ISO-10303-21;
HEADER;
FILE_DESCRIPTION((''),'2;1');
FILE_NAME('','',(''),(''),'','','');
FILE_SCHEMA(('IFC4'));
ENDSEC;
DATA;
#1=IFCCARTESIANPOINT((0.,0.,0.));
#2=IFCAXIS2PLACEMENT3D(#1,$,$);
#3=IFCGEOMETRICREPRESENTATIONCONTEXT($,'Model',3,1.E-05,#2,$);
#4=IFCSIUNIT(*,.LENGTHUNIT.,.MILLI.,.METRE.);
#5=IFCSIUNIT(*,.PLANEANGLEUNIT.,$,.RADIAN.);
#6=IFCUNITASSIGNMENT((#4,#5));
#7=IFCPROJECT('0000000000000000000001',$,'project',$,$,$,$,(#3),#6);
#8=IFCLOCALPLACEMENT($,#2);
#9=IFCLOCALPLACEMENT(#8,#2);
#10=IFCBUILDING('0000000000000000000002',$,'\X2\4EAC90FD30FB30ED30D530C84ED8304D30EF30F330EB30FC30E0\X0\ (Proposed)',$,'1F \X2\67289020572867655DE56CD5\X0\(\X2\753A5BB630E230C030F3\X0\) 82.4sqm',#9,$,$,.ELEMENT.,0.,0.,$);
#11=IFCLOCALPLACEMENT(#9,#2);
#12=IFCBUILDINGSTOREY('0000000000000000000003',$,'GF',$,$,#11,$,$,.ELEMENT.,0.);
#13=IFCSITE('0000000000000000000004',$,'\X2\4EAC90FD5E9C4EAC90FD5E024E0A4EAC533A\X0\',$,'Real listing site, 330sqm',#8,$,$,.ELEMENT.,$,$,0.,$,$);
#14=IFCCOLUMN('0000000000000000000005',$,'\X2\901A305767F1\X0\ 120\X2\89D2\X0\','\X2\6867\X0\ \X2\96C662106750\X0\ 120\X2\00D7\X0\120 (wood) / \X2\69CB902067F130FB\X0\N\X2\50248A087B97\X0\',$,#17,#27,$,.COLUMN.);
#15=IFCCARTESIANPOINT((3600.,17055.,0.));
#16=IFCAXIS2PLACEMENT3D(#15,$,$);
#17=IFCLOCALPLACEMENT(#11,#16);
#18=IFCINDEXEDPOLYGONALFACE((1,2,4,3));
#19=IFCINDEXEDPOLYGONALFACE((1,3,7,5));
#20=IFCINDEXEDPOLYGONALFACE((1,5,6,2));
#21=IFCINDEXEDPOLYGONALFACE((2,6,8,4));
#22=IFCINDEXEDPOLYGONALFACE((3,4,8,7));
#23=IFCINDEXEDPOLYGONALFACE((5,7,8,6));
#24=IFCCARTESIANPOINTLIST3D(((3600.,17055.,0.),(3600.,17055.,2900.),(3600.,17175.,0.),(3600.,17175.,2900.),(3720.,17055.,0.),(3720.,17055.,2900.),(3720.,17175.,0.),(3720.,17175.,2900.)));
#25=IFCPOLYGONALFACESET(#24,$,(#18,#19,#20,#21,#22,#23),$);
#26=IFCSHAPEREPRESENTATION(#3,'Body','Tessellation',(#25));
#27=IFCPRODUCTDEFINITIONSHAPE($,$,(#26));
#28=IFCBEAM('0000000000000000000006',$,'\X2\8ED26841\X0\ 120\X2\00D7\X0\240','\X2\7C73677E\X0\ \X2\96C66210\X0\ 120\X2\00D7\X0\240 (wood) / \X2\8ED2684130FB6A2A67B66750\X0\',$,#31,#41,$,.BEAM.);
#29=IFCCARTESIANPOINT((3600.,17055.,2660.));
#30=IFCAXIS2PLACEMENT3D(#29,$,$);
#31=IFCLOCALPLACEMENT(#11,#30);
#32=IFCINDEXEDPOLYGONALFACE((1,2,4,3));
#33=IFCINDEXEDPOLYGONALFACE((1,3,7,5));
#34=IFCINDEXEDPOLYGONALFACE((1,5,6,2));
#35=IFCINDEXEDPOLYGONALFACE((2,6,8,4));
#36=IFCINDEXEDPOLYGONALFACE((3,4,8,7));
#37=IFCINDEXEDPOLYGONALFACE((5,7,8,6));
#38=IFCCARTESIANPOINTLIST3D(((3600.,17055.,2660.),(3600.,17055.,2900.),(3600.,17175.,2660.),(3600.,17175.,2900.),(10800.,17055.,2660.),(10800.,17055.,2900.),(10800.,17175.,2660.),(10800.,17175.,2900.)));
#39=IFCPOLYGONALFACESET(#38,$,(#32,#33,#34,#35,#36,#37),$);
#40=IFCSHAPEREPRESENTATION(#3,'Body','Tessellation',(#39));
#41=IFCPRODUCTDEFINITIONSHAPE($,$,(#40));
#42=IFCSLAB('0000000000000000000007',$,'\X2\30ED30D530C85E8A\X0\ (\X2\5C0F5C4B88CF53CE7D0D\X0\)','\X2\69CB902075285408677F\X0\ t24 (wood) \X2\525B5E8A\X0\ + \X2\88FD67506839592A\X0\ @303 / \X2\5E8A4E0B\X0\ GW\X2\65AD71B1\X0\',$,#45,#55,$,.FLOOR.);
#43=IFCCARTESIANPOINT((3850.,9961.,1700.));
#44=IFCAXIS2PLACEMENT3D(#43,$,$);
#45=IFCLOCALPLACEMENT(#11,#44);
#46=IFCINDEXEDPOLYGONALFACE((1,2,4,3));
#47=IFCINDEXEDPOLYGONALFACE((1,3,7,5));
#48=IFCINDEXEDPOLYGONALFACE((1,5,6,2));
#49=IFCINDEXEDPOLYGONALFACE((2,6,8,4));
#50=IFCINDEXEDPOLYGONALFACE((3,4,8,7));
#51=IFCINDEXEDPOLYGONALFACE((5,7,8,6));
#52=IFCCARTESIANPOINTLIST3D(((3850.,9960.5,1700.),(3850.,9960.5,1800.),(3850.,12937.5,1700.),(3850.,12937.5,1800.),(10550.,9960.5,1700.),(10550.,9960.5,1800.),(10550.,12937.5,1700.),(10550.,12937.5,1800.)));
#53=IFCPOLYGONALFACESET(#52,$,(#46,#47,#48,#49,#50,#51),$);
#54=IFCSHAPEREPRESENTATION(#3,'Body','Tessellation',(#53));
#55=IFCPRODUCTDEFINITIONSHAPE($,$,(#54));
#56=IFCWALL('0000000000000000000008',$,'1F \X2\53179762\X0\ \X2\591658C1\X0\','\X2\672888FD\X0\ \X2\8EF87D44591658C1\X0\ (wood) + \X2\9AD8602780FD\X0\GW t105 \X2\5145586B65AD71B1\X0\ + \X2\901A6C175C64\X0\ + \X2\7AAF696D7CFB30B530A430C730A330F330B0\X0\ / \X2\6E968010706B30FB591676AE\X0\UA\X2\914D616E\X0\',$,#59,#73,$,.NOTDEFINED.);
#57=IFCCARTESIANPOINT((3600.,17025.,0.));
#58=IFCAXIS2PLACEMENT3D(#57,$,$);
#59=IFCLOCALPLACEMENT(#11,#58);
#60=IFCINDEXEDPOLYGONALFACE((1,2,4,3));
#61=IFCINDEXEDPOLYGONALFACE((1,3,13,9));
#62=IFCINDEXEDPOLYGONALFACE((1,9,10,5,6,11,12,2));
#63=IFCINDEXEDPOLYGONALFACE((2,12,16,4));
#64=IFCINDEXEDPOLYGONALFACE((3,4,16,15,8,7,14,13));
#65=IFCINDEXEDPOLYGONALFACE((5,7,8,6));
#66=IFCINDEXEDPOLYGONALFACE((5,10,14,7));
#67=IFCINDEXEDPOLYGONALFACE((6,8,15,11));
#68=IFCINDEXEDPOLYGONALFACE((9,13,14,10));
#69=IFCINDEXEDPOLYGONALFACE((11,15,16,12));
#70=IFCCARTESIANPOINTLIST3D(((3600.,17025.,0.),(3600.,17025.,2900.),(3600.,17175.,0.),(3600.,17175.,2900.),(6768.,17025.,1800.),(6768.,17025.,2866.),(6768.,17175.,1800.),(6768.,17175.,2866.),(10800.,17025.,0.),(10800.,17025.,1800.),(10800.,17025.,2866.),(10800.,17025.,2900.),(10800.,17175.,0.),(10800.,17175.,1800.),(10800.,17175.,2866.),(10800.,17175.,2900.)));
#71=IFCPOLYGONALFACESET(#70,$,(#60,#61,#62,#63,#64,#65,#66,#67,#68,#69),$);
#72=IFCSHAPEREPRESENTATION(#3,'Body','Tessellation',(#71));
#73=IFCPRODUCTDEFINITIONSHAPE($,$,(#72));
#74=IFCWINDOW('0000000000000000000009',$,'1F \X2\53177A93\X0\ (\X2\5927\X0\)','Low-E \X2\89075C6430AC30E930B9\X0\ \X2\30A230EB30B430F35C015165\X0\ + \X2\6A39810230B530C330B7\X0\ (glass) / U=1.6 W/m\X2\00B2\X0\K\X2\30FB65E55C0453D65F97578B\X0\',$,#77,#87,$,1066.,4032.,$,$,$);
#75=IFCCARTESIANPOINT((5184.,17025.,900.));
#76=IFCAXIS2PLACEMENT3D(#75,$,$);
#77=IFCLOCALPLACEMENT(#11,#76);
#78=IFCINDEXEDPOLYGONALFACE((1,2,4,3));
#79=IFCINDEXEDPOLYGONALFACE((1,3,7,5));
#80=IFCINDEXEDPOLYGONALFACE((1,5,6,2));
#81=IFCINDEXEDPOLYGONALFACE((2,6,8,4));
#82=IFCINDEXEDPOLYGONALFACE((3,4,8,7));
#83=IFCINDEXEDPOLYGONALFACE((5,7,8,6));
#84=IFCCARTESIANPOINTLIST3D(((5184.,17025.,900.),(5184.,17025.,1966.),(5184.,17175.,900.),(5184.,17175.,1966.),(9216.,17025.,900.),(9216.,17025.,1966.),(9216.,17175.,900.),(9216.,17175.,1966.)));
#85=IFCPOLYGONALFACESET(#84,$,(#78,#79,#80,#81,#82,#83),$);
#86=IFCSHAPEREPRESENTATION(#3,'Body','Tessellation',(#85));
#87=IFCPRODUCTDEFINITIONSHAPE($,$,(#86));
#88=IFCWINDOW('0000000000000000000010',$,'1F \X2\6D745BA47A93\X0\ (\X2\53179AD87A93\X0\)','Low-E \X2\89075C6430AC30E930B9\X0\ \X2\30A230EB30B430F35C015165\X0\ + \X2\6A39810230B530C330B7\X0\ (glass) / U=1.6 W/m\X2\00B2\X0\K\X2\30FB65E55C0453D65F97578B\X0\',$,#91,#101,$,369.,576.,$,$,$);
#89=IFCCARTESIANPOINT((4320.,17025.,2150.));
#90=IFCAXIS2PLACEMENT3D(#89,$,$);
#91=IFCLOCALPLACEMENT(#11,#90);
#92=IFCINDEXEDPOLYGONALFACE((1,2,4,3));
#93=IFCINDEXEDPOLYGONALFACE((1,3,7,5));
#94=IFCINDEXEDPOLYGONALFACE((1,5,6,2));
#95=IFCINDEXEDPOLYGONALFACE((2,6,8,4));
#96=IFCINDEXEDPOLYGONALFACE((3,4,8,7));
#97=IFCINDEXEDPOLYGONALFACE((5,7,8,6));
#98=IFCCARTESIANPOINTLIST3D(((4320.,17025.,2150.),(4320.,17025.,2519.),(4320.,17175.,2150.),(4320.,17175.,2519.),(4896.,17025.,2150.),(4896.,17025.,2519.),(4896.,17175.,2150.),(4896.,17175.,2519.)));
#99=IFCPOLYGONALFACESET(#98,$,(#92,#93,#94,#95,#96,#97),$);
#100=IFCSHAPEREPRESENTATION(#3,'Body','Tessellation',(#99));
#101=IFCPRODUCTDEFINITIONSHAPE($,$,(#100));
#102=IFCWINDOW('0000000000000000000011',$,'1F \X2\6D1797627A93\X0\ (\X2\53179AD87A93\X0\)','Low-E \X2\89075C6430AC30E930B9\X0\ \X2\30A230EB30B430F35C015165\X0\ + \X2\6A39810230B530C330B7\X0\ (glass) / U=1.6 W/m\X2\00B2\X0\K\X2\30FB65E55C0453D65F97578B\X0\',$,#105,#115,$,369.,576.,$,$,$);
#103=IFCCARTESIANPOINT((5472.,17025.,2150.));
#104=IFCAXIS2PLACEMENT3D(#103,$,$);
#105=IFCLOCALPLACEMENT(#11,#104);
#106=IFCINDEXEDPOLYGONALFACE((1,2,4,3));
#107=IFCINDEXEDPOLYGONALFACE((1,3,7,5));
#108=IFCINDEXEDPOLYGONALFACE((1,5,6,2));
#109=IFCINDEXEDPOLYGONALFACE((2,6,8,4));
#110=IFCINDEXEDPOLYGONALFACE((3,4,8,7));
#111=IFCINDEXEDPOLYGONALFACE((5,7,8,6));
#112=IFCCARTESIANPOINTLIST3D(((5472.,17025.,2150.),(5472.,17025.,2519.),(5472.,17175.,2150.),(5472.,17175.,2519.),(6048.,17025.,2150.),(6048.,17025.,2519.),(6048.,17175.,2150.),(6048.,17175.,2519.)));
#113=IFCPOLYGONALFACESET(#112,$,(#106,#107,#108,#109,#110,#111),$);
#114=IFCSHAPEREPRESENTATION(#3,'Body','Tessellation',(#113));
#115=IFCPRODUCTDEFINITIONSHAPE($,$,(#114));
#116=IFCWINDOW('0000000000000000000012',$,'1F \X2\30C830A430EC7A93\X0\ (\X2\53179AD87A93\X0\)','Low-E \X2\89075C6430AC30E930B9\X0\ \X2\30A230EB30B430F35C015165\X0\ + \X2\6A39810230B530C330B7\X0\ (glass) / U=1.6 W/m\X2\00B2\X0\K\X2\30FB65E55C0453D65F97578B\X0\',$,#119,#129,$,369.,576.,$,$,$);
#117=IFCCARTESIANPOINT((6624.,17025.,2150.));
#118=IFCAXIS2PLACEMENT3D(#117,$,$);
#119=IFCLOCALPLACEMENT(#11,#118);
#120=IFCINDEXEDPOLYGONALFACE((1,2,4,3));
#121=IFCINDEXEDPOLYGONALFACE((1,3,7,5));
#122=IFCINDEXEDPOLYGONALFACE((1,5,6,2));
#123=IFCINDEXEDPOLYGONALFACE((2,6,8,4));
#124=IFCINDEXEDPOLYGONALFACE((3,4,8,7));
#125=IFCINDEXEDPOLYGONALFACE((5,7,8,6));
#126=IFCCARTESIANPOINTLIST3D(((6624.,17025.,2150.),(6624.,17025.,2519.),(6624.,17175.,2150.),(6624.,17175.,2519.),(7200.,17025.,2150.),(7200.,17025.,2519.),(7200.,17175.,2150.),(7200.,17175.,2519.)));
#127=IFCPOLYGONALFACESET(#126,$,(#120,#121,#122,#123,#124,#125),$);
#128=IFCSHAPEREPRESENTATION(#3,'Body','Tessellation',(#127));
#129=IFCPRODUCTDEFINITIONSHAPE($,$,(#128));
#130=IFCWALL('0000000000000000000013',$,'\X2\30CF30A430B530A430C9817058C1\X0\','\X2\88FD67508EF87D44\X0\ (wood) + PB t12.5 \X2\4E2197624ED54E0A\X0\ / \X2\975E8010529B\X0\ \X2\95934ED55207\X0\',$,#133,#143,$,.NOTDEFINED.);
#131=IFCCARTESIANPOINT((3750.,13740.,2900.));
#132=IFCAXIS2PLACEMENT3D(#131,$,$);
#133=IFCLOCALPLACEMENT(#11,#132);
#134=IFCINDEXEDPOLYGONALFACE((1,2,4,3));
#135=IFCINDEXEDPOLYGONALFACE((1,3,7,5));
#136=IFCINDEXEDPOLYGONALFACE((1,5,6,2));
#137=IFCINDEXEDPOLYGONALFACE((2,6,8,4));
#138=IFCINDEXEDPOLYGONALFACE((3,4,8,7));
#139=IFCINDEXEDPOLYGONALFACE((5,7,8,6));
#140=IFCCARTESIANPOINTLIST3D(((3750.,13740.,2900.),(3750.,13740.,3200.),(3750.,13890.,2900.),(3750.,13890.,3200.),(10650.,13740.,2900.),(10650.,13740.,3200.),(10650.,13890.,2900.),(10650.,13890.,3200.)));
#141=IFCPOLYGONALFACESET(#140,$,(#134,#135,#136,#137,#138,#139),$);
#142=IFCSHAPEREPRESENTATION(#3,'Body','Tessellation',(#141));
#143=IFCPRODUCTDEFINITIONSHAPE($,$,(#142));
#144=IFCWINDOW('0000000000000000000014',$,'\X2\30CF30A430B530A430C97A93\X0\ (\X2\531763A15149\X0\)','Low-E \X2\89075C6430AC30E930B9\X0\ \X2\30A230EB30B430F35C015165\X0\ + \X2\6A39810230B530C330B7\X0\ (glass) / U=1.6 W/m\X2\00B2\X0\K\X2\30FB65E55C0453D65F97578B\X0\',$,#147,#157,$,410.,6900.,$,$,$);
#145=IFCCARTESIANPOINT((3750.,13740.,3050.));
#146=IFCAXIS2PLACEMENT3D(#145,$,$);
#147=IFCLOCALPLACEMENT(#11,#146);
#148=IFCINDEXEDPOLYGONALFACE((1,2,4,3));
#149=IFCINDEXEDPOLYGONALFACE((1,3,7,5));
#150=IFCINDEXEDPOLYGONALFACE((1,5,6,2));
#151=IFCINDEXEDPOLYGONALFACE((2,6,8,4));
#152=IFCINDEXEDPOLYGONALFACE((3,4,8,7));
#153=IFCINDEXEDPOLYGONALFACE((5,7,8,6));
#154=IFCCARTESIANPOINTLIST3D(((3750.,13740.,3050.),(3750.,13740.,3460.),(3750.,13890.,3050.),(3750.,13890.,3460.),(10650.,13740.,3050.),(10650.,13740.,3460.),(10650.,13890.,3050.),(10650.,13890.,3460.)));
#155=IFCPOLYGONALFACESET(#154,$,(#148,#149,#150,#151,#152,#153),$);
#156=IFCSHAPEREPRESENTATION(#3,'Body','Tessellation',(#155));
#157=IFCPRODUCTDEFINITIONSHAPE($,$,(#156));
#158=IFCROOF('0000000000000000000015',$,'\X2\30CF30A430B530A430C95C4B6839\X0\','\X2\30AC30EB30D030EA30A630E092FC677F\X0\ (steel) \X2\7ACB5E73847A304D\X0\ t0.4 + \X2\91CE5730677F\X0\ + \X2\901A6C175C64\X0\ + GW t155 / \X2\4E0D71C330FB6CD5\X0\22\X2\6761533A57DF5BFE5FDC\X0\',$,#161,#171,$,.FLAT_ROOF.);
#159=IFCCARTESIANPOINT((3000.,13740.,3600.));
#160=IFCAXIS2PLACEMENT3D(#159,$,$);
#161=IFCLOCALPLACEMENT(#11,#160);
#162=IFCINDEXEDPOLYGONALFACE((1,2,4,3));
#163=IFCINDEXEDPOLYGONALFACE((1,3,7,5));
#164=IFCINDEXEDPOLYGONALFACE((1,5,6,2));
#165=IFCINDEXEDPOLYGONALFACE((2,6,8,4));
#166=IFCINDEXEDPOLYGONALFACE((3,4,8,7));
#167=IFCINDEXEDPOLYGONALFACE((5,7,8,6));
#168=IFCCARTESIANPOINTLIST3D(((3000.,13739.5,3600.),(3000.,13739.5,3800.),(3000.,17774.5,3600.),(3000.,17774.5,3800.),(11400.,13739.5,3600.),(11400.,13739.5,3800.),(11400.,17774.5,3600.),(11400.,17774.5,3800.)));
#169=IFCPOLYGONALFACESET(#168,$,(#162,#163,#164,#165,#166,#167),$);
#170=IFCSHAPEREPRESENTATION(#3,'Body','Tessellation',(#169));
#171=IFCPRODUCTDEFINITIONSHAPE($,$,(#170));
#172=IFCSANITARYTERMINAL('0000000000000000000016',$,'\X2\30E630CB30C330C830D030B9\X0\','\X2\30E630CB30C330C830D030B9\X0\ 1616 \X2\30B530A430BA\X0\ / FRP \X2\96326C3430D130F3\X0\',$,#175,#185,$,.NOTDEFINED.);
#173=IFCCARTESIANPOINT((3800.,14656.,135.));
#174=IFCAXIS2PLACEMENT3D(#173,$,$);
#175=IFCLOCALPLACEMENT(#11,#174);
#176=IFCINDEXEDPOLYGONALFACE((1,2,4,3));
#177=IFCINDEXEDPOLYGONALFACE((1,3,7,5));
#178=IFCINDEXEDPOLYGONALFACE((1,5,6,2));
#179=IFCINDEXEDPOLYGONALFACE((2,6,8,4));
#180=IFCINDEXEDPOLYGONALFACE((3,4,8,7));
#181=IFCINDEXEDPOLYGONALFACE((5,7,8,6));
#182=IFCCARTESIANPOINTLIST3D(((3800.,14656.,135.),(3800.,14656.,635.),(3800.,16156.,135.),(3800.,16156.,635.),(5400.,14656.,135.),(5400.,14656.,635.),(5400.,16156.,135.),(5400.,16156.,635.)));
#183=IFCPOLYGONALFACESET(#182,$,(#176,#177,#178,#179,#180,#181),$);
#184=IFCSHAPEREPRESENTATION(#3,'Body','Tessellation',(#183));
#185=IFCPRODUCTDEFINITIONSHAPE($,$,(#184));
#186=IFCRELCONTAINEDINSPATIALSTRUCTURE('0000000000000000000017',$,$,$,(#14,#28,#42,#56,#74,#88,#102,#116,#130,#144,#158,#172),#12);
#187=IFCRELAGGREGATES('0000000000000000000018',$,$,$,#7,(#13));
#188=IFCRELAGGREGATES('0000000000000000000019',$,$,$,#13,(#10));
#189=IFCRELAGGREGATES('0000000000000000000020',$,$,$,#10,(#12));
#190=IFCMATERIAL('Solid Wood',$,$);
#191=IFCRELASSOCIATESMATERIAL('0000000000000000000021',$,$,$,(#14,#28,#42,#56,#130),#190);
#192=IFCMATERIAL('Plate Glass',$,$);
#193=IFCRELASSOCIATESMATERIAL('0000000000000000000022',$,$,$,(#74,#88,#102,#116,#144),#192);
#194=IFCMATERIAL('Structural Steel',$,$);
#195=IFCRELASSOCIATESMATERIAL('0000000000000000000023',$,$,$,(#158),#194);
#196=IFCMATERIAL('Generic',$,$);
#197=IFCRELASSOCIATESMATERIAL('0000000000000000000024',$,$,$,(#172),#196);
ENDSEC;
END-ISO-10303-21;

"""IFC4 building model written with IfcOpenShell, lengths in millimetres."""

from ifc_helpers import new_model, si_unit, frame, frame_2d, origin, place, context, project, spatial, rectangle, extrude, material, element, fill, save


model = new_model("IFC4")

# Units and contexts
model_context = context("Model", 3, precision=1e-05, world=origin())
ifc_project = project(units=[si_unit("LENGTHUNIT", "METRE", prefix="MILLI"), si_unit("PLANEANGLEUNIT", "RADIAN")], contexts=[model_context])

# Site, building, storey
site_placement = place(None, origin())
site = spatial("IfcSite", under=ifc_project, at=site_placement, Name="京都府京都市上京区", ObjectType="Real listing site, 330sqm", CompositionType="ELEMENT", RefElevation=0.0)
building_placement = place(site_placement, origin())
building = spatial("IfcBuilding", under=site, at=building_placement, Name="京都・ロフト付きワンルーム (Proposed)", ObjectType="1F 木造在来工法(町家モダン) 82.4sqm", CompositionType="ELEMENT", ElevationOfRefHeight=0.0, ElevationOfTerrain=0.0)
storey_placement = place(building_placement, origin())
storey = spatial("IfcBuildingStorey", under=building, at=storey_placement, Name="GF", CompositionType="ELEMENT", Elevation=0.0)

# Column
ifc_material_1 = material(Name="Solid Wood")
column_1_placement = place(storey_placement, frame((3600.0, 17055.0, 0.0)))
element("IfcColumn", 1, at=column_1_placement, inside=storey, material=ifc_material_1, Name="通し柱 120角", Description="桧 集成材 120×120 (wood) / 構造柱・N値計算", PredefinedType="COLUMN", context=model_context, shape_type="SweptSolid", body=[
    extrude(rectangle(XDim=120.0, YDim=120.0, at=frame_2d((60.0, 60.0))), frame((3600.0, 17055.0, 0.0)), (0.0, 0.0, 1.0), 2900.0),
])

# Beam
beam_1_placement = place(storey_placement, frame((3600.0, 17055.0, 2660.0)))
element("IfcBeam", 2, at=beam_1_placement, inside=storey, material=ifc_material_1, Name="軒桁 120×240", Description="米松 集成 120×240 (wood) / 軒桁・横架材", PredefinedType="BEAM", context=model_context, shape_type="SweptSolid", body=[
    extrude(rectangle(XDim=7200.0, YDim=120.0, at=frame_2d((3600.0, 60.0))), frame((3600.0, 17055.0, 2660.0)), (0.0, 0.0, 1.0), 240.0),
])

# Slab
slab_placement = place(storey_placement, frame((3850.0, 9961.0, 1700.0)))
element("IfcSlab", 3, at=slab_placement, inside=storey, material=ifc_material_1, Name="ロフト床 (小屋裏収納)", Description="構造用合板 t24 (wood) 剛床 + 製材根太 @303 / 床下 GW断熱", PredefinedType="FLOOR", context=model_context, shape_type="SweptSolid", body=[
    extrude(rectangle(XDim=6700.0, YDim=2977.0, at=frame_2d((3350.0, 1488.0))), frame((3850.0, 9961.0, 1700.0)), (0.0, 0.0, 1.0), 100.0),
])

# Wall, openings, windows
wall_1_placement = place(storey_placement, frame((3600.0, 17025.0, 0.0)))
wall_1 = element("IfcWall", 4, at=wall_1_placement, inside=storey, material=ifc_material_1, Name="1F 北面 外壁", Description="木製 軸組外壁 (wood) + 高性能GW t105 充填断熱 + 通気層 + 窯業系サイディング / 準耐火・外皮UA配慮", PredefinedType="NOTDEFINED", context=model_context, shape_type="SweptSolid", body=[
    extrude(rectangle(XDim=7200.0, YDim=150.0, at=frame_2d((3600.0, 75.0))), frame((3600.0, 17025.0, 0.0)), (0.0, 0.0, 1.0), 2900.0),
])
opening_1_placement = place(storey_placement, frame((5184.0, 17025.0, 900.0)))
opening_1 = element("IfcOpeningElement", 5, at=opening_1_placement, cuts=wall_1, PredefinedType="NOTDEFINED", context=model_context, shape_type="SweptSolid", body=[
    extrude(rectangle(XDim=4032.0, YDim=150.0, at=frame_2d((2016.0, 75.0))), frame((5184.0, 17025.0, 900.0)), (0.0, 0.0, 1.0), 1066.0),
])
opening_2_placement = place(storey_placement, frame((4320.0, 17025.0, 2150.0)))
opening_2 = element("IfcOpeningElement", 6, at=opening_2_placement, cuts=wall_1, PredefinedType="NOTDEFINED", context=model_context, shape_type="SweptSolid", body=[
    extrude(rectangle(XDim=576.0, YDim=150.0, at=frame_2d((288.0, 75.0))), frame((4320.0, 17025.0, 2150.0)), (0.0, 0.0, 1.0), 369.0),
])
opening_3_placement = place(storey_placement, frame((5472.0, 17025.0, 2150.0)))
opening_3 = element("IfcOpeningElement", 7, at=opening_3_placement, cuts=wall_1, PredefinedType="NOTDEFINED", context=model_context, shape_type="SweptSolid", body=[
    extrude(rectangle(XDim=576.0, YDim=150.0, at=frame_2d((288.0, 75.0))), frame((5472.0, 17025.0, 2150.0)), (0.0, 0.0, 1.0), 369.0),
])
opening_4_placement = place(storey_placement, frame((6624.0, 17025.0, 2150.0)))
opening_4 = element("IfcOpeningElement", 8, at=opening_4_placement, cuts=wall_1, PredefinedType="NOTDEFINED", context=model_context, shape_type="SweptSolid", body=[
    extrude(rectangle(XDim=576.0, YDim=150.0, at=frame_2d((288.0, 75.0))), frame((6624.0, 17025.0, 2150.0)), (0.0, 0.0, 1.0), 369.0),
])
ifc_material_2 = material(Name="Plate Glass")
window_1_placement = place(storey_placement, frame((5184.0, 17025.0, 900.0)))
window_1 = element("IfcWindow", 9, at=window_1_placement, inside=storey, material=ifc_material_2, Name="1F 北窓 (大)", Description="Low-E 複層ガラス アルゴン封入 + 樹脂サッシ (glass) / U=1.6 W/m²K・日射取得型", OverallHeight=1066.0, OverallWidth=4032.0, context=model_context, shape_type="SweptSolid", body=[
    extrude(rectangle(XDim=4032.0, YDim=150.0, at=frame_2d((2016.0, 75.0))), frame((5184.0, 17025.0, 900.0)), (0.0, 0.0, 1.0), 1066.0),
])
fill(opening_1, window_1)
window_2_placement = place(storey_placement, frame((4320.0, 17025.0, 2150.0)))
window_2 = element("IfcWindow", 10, at=window_2_placement, inside=storey, material=ifc_material_2, Name="1F 浴室窓 (北高窓)", Description="Low-E 複層ガラス アルゴン封入 + 樹脂サッシ (glass) / U=1.6 W/m²K・日射取得型", OverallHeight=369.0, OverallWidth=576.0, context=model_context, shape_type="SweptSolid", body=[
    extrude(rectangle(XDim=576.0, YDim=150.0, at=frame_2d((288.0, 75.0))), frame((4320.0, 17025.0, 2150.0)), (0.0, 0.0, 1.0), 369.0),
])
fill(opening_2, window_2)
window_3_placement = place(storey_placement, frame((5472.0, 17025.0, 2150.0)))
window_3 = element("IfcWindow", 11, at=window_3_placement, inside=storey, material=ifc_material_2, Name="1F 洗面窓 (北高窓)", Description="Low-E 複層ガラス アルゴン封入 + 樹脂サッシ (glass) / U=1.6 W/m²K・日射取得型", OverallHeight=369.0, OverallWidth=576.0, context=model_context, shape_type="SweptSolid", body=[
    extrude(rectangle(XDim=576.0, YDim=150.0, at=frame_2d((288.0, 75.0))), frame((5472.0, 17025.0, 2150.0)), (0.0, 0.0, 1.0), 369.0),
])
fill(opening_3, window_3)
window_4_placement = place(storey_placement, frame((6624.0, 17025.0, 2150.0)))
window_4 = element("IfcWindow", 12, at=window_4_placement, inside=storey, material=ifc_material_2, Name="1F トイレ窓 (北高窓)", Description="Low-E 複層ガラス アルゴン封入 + 樹脂サッシ (glass) / U=1.6 W/m²K・日射取得型", OverallHeight=369.0, OverallWidth=576.0, context=model_context, shape_type="SweptSolid", body=[
    extrude(rectangle(XDim=576.0, YDim=150.0, at=frame_2d((288.0, 75.0))), frame((6624.0, 17025.0, 2150.0)), (0.0, 0.0, 1.0), 369.0),
])
fill(opening_4, window_4)

# Wall, opening, window
wall_2_placement = place(storey_placement, frame((3750.0, 13740.0, 2900.0)))
wall_2 = element("IfcWall", 13, at=wall_2_placement, inside=storey, material=ifc_material_1, Name="ハイサイド腰壁", Description="製材軸組 (wood) + PB t12.5 両面仕上 / 非耐力 間仕切", PredefinedType="NOTDEFINED", context=model_context, shape_type="SweptSolid", body=[
    extrude(rectangle(XDim=6900.0, YDim=150.0, at=frame_2d((3450.0, 75.0))), frame((3750.0, 13740.0, 2900.0)), (0.0, 0.0, 1.0), 700.0),
])
opening_5_placement = place(storey_placement, frame((3750.0, 13740.0, 3050.0)))
opening_5 = element("IfcOpeningElement", 14, at=opening_5_placement, cuts=wall_2, PredefinedType="NOTDEFINED", context=model_context, shape_type="SweptSolid", body=[
    extrude(rectangle(XDim=6900.0, YDim=150.0, at=frame_2d((3450.0, 75.0))), frame((3750.0, 13740.0, 3050.0)), (0.0, 0.0, 1.0), 410.0),
])
window_5_placement = place(storey_placement, frame((3750.0, 13740.0, 3050.0)))
window_5 = element("IfcWindow", 15, at=window_5_placement, inside=storey, material=ifc_material_2, Name="ハイサイド窓 (北採光)", Description="Low-E 複層ガラス アルゴン封入 + 樹脂サッシ (glass) / U=1.6 W/m²K・日射取得型", OverallHeight=410.0, OverallWidth=6900.0, context=model_context, shape_type="SweptSolid", body=[
    extrude(rectangle(XDim=6900.0, YDim=150.0, at=frame_2d((3450.0, 75.0))), frame((3750.0, 13740.0, 3050.0)), (0.0, 0.0, 1.0), 410.0),
])
fill(opening_5, window_5)

# Roof
ifc_material_3 = material(Name="Structural Steel")
roof_placement = place(storey_placement, frame((3000.0, 13740.0, 3600.0)))
element("IfcRoof", 16, at=roof_placement, inside=storey, material=ifc_material_3, Name="ハイサイド屋根", Description="ガルバリウム鋼板 (steel) 立平葺き t0.4 + 野地板 + 通気層 + GW t155 / 不燃・法22条区域対応", PredefinedType="FLAT_ROOF", context=model_context, shape_type="SweptSolid", body=[
    extrude(rectangle(XDim=8400.0, YDim=4035.0, at=frame_2d((4200.0, 2017.0))), frame((3000.0, 13740.0, 3600.0)), (0.0, 0.0, 1.0), 200.0),
])

# Sanitary terminal
ifc_material_4 = material(Name="Generic")
sanitary_terminal_placement = place(storey_placement, frame((3800.0, 14656.0, 135.0)))
element("IfcSanitaryTerminal", 17, at=sanitary_terminal_placement, inside=storey, material=ifc_material_4, Name="ユニットバス", Description="ユニットバス 1616 サイズ / FRP 防水パン", PredefinedType="NOTDEFINED", context=model_context, shape_type="SweptSolid", body=[
    extrude(rectangle(XDim=1600.0, YDim=1500.0, at=frame_2d((800.0, 750.0))), frame((3800.0, 14656.0, 135.0)), (0.0, 0.0, 1.0), 500.0),
])

save(model, "model.ifc")
